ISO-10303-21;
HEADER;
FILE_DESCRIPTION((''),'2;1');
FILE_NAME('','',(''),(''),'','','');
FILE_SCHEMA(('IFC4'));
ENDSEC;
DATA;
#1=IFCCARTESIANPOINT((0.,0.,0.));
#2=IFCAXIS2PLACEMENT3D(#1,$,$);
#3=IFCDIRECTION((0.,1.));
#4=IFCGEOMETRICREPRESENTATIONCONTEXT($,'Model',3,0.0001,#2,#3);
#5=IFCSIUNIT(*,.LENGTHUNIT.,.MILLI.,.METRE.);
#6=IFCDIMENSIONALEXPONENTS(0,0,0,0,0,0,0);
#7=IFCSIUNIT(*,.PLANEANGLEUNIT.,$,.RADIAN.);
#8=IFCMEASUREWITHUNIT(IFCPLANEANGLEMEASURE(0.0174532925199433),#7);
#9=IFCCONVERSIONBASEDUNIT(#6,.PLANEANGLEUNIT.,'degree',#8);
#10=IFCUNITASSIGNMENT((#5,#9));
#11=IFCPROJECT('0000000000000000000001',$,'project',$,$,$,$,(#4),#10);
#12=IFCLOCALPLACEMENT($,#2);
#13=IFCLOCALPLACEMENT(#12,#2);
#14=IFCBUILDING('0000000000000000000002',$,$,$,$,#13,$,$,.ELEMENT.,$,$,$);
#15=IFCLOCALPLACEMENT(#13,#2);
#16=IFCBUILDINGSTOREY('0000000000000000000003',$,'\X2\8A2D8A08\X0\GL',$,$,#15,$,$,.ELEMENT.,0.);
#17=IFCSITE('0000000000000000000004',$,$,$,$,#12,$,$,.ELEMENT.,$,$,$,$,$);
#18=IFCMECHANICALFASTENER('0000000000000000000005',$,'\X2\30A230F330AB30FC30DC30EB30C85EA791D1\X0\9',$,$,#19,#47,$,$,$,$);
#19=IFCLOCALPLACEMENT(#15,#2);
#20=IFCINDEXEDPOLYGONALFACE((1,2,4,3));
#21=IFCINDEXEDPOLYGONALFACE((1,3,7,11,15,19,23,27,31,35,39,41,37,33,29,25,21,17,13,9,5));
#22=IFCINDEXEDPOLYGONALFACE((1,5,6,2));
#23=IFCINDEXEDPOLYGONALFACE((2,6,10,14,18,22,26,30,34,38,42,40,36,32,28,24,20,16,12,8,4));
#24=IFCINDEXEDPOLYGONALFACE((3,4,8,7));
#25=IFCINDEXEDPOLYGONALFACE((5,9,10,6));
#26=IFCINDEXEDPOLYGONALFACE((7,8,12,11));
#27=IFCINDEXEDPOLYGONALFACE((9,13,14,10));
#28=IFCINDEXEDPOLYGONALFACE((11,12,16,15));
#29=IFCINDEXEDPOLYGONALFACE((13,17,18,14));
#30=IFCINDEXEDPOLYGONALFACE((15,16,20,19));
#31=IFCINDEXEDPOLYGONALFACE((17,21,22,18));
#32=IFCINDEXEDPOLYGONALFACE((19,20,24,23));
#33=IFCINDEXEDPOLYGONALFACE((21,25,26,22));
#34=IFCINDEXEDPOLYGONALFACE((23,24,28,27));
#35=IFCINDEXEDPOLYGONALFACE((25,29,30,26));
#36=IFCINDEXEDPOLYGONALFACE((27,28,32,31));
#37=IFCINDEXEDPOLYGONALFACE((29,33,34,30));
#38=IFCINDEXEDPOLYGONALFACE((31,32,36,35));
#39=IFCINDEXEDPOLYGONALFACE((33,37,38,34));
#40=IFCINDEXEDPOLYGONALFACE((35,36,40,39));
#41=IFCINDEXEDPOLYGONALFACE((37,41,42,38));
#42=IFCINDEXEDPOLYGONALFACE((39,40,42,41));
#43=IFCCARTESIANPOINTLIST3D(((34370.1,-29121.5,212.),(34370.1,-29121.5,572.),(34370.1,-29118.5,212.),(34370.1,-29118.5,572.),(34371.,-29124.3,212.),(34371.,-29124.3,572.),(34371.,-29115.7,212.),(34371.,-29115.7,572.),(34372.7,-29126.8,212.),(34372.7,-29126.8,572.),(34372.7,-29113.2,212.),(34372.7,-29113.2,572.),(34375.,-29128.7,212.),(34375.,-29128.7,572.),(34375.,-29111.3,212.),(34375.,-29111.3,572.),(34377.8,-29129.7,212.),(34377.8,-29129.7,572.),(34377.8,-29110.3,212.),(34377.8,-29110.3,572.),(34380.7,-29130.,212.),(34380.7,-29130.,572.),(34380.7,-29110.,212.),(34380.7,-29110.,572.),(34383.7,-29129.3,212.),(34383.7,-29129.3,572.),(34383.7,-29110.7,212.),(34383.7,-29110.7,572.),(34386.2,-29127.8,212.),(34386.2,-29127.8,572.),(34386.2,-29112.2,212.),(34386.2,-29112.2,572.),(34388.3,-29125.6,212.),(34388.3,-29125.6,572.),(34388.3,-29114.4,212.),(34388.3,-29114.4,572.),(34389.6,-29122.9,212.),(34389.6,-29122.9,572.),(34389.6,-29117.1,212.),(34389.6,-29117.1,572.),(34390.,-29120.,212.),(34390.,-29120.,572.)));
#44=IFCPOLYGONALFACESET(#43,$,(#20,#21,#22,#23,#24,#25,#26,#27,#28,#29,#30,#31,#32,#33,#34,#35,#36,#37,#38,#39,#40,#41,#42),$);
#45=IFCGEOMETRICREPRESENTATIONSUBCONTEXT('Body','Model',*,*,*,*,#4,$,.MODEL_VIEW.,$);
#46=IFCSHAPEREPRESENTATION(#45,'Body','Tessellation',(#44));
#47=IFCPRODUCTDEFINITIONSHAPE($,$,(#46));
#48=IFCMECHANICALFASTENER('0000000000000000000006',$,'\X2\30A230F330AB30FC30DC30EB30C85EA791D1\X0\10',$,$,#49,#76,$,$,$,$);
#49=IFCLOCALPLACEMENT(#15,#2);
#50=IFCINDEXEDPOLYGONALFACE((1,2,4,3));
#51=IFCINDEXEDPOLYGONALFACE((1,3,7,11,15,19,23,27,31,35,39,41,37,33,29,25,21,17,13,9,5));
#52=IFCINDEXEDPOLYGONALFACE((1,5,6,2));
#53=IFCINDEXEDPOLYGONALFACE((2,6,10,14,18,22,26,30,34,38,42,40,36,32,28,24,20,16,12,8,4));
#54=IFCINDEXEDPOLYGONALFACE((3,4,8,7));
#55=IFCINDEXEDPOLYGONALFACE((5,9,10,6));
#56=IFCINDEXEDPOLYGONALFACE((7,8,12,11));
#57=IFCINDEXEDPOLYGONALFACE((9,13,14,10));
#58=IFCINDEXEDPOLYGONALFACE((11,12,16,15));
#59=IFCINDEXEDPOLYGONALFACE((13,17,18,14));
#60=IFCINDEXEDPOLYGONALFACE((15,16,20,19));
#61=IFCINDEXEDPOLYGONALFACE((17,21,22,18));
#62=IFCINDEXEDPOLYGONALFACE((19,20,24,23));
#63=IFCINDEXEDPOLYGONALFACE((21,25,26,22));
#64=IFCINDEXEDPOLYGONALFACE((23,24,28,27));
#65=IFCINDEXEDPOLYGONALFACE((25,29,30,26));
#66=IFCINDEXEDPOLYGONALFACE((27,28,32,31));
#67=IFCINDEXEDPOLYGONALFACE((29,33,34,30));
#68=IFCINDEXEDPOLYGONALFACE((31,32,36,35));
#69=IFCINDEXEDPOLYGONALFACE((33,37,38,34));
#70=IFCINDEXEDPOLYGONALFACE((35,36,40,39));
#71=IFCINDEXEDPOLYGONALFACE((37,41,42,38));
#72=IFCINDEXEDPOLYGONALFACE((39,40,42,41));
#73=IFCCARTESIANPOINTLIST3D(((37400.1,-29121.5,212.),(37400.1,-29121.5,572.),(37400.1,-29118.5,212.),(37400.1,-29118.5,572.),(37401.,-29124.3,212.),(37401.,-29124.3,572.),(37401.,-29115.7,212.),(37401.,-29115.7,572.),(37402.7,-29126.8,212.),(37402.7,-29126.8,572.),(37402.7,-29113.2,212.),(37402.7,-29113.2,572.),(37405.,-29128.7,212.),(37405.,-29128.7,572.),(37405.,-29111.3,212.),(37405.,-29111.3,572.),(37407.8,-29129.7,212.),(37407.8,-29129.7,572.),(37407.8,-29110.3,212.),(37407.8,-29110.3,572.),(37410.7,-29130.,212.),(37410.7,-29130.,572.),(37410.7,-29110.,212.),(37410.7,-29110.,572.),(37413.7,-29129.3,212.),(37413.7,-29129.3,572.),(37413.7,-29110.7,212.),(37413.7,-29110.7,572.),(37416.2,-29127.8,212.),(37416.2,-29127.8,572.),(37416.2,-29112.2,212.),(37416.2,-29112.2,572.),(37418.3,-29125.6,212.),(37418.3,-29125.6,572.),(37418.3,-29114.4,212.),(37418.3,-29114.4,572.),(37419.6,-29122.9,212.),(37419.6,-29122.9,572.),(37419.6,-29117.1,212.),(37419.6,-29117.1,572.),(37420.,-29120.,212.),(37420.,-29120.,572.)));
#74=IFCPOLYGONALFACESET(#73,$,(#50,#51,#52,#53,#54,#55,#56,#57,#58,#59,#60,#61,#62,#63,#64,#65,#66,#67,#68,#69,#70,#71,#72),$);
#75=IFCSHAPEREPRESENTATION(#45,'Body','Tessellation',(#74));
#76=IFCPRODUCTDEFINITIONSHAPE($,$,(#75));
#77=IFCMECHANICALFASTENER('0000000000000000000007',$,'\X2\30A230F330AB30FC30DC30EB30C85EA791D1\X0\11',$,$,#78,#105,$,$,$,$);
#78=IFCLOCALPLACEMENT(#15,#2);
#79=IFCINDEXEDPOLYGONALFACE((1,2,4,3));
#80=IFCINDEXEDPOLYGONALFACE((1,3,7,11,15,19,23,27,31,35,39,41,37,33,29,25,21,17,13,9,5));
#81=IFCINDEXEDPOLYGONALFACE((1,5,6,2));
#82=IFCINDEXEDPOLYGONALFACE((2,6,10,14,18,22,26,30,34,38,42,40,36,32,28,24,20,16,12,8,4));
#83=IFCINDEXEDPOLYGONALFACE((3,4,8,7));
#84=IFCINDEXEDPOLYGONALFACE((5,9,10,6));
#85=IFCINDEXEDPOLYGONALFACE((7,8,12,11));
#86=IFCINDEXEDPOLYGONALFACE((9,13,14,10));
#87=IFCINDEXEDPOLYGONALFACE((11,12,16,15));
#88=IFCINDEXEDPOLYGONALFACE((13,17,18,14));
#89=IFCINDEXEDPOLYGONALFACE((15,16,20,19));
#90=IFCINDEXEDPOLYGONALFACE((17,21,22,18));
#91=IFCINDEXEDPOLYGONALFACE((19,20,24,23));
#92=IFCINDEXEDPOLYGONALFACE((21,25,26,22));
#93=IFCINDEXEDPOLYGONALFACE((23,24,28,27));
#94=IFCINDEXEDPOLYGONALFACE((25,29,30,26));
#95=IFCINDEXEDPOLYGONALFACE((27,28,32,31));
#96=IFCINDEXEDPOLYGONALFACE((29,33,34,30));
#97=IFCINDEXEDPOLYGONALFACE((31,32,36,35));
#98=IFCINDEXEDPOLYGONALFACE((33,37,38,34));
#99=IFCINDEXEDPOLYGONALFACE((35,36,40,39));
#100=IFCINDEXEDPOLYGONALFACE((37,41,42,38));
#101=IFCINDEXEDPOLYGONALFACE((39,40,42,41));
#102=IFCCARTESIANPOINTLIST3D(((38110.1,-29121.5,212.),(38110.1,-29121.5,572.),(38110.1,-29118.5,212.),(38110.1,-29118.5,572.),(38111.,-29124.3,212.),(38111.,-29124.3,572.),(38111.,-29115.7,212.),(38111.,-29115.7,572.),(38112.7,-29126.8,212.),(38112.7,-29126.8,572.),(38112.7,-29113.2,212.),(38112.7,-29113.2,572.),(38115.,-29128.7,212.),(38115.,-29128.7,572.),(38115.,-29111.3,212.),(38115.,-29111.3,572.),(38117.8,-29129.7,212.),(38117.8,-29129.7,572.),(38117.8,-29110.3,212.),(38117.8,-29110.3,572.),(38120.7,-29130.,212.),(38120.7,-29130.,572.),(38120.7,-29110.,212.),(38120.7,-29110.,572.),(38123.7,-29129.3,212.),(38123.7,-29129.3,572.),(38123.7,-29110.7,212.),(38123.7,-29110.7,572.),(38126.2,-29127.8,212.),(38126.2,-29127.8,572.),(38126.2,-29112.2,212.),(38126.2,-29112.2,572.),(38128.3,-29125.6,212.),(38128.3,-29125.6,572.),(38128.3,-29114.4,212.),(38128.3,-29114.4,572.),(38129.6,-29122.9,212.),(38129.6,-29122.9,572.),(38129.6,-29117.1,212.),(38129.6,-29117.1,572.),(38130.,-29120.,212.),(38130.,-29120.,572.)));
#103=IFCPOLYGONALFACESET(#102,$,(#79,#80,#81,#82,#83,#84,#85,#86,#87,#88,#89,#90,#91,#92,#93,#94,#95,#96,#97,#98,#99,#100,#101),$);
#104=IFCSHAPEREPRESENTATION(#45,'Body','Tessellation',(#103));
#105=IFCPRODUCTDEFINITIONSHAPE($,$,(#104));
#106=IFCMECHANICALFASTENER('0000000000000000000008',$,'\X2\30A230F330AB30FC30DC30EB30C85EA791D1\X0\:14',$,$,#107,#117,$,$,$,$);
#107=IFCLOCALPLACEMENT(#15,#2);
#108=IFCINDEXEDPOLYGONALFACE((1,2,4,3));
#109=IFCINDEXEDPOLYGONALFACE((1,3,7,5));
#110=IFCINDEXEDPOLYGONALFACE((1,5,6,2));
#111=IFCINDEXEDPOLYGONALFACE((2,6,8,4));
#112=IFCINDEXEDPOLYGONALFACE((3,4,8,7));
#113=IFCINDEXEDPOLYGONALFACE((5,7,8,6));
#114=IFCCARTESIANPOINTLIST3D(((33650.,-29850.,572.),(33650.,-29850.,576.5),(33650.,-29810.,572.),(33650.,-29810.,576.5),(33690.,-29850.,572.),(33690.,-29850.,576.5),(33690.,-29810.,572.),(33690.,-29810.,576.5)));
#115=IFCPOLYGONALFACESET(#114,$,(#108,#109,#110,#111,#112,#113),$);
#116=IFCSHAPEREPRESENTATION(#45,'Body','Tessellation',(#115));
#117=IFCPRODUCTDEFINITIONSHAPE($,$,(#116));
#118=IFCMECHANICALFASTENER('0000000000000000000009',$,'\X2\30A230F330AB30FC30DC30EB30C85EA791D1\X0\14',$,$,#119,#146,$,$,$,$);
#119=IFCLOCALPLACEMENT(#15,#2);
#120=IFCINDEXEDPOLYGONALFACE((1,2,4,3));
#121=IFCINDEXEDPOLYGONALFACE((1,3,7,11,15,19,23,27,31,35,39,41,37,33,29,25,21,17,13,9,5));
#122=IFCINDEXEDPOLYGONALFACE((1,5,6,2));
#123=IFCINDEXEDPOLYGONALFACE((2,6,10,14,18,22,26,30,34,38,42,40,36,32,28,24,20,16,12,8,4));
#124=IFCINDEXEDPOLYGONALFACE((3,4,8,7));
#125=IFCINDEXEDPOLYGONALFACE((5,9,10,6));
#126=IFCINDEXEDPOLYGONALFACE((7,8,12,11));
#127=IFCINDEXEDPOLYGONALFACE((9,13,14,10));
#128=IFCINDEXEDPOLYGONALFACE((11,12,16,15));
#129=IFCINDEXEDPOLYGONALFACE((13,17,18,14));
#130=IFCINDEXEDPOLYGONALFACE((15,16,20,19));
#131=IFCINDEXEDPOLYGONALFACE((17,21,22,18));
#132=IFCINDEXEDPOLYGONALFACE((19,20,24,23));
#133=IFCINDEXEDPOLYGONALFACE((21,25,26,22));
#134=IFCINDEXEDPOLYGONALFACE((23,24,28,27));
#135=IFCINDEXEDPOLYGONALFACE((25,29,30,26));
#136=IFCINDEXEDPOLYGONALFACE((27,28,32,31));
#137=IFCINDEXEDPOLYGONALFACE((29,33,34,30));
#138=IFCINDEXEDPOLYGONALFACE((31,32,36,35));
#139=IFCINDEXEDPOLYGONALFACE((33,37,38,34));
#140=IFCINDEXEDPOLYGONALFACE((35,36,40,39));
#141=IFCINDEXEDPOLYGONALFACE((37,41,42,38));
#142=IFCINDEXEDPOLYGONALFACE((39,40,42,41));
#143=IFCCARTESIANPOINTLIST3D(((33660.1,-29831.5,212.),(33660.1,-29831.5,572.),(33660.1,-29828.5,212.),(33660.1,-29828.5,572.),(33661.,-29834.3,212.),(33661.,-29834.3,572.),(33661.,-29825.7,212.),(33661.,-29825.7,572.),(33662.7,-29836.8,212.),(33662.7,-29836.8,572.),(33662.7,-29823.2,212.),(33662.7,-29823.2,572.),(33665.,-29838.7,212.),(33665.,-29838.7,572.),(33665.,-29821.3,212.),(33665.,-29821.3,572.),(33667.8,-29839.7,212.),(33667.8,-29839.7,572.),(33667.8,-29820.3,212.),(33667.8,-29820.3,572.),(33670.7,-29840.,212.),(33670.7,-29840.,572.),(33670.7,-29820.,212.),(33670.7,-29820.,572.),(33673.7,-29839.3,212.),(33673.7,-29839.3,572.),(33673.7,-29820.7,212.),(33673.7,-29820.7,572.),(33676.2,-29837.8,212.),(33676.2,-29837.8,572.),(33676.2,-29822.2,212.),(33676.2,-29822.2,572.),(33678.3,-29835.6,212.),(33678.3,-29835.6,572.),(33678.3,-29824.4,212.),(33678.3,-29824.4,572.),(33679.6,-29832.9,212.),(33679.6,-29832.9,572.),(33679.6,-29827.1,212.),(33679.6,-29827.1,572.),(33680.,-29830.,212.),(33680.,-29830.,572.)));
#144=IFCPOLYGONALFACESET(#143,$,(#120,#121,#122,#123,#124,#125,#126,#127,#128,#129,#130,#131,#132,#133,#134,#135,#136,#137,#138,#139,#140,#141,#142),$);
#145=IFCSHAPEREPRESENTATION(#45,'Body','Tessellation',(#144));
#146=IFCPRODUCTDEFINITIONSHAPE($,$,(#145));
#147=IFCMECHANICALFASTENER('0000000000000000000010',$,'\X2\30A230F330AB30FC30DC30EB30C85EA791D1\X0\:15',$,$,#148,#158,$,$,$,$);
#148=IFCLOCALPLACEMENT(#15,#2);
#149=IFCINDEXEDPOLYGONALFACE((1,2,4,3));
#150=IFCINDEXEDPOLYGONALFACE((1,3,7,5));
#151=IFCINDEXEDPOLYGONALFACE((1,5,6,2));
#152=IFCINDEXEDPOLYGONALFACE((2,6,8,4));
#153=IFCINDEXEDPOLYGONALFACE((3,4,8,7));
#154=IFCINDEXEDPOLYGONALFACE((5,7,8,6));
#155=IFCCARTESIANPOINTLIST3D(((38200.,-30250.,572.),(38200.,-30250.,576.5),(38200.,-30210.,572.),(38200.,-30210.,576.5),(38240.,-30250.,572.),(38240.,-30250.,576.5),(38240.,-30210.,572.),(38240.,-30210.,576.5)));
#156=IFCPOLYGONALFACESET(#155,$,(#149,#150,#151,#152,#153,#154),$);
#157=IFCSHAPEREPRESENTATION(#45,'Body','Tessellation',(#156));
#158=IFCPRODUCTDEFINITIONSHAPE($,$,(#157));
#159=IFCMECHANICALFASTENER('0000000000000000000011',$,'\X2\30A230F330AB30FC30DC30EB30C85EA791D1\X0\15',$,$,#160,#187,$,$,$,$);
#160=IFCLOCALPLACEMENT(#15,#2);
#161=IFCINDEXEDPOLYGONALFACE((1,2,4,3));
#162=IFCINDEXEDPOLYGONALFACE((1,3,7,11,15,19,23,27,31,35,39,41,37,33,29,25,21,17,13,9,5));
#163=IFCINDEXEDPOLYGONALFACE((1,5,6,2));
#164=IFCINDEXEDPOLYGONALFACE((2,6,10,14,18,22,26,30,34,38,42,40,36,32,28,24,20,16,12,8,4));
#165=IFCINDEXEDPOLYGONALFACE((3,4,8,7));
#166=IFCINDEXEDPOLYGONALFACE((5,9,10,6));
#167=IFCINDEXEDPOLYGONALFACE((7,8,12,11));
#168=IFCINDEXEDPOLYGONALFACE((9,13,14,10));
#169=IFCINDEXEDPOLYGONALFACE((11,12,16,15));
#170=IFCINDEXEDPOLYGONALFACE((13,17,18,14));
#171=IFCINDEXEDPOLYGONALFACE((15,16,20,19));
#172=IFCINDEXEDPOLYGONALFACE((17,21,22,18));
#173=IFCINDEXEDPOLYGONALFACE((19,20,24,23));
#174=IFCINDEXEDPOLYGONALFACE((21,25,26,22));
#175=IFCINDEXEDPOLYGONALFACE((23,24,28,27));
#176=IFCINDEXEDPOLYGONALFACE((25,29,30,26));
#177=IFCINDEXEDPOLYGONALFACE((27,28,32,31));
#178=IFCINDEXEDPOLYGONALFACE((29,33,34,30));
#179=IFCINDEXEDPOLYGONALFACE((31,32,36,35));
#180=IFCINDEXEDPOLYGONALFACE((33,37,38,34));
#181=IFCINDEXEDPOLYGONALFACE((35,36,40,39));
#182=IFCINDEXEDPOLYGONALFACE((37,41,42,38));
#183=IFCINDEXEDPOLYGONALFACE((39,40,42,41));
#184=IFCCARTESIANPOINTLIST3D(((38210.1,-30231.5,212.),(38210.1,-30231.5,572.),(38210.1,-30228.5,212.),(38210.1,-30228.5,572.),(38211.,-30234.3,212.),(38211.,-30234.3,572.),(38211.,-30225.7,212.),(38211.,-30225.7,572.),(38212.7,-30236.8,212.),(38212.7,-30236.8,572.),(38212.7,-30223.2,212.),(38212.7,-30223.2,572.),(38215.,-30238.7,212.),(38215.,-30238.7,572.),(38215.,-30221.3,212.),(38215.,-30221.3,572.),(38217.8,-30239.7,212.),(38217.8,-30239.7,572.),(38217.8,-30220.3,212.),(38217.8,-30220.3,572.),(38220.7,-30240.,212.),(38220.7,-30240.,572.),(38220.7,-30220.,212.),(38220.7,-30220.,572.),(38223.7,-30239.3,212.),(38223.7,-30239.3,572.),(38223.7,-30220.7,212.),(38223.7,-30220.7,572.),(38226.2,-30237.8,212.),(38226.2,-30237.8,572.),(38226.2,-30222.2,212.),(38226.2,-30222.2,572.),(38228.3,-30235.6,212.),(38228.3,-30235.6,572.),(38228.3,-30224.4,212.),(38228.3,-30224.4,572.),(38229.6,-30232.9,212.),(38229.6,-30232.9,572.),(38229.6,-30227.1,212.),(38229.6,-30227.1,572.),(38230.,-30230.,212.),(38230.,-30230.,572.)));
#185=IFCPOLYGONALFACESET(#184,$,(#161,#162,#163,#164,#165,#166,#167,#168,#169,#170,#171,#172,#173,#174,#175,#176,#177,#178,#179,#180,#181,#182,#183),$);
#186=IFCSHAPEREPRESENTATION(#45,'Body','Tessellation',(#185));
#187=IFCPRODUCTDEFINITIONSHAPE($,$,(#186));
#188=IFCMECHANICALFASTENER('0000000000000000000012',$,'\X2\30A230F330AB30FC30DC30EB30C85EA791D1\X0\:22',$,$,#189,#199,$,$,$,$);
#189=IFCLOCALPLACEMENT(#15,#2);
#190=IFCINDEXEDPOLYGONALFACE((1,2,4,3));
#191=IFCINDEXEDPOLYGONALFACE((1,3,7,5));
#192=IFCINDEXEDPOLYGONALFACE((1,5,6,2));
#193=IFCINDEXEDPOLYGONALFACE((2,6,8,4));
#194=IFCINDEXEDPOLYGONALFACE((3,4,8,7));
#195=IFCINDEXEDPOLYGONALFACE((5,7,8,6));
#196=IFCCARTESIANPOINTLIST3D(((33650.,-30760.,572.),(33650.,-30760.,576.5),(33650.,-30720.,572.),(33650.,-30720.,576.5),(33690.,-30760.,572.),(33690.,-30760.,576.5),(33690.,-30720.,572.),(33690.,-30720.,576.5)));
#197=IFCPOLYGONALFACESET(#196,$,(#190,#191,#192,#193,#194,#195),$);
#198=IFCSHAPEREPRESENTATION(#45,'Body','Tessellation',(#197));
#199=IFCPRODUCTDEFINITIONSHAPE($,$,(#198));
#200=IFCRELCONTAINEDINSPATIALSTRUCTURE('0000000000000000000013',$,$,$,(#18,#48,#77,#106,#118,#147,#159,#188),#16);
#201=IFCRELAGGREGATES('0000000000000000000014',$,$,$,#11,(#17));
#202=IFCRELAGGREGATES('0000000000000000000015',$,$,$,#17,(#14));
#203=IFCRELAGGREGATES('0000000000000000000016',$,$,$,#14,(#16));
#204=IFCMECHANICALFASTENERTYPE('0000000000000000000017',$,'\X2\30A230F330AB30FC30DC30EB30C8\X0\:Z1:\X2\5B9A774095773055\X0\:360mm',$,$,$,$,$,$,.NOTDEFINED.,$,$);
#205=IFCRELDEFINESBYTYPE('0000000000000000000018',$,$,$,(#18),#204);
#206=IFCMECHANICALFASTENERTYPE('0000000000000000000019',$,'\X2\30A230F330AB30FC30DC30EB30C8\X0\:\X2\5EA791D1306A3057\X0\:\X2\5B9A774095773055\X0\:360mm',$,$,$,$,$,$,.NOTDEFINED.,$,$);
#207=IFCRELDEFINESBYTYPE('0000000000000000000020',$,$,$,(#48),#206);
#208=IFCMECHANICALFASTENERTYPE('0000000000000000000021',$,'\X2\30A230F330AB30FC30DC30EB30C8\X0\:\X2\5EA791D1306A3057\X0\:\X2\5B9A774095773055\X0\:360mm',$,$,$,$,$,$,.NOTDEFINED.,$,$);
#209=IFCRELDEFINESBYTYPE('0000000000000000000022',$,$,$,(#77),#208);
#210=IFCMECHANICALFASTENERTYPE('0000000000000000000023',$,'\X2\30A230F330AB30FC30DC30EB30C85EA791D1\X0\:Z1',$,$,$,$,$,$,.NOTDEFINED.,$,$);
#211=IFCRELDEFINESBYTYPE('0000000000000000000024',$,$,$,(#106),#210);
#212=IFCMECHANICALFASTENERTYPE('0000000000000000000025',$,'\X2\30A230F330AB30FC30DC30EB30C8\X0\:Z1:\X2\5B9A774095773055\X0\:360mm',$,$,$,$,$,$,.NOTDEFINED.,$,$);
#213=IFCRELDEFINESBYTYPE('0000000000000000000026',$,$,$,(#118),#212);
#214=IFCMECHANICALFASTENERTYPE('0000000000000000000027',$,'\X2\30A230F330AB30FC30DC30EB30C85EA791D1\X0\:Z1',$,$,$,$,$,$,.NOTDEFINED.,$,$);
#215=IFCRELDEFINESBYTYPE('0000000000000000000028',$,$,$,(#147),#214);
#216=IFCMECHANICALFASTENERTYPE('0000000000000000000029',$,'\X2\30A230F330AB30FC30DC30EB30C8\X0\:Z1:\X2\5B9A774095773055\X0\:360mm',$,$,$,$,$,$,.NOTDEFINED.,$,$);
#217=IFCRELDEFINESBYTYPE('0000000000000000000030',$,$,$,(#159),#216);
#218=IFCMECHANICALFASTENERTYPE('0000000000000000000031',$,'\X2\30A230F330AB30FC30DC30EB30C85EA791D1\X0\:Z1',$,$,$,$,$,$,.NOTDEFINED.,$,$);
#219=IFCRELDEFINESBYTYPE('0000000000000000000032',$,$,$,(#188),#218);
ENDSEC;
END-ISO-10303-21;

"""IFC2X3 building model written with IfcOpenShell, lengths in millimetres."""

from ifc_helpers import new_model, entity, si_unit, converted_unit, direction, frame, origin, origin_with_axes, origin_2d, place, context, subcontext, project, spatial, rectangle, circle, extrude, type_object, element, save


model = new_model("IFC2X3")

# Units and contexts
model_context = context("Model", 3, precision=0.0001, world=origin(), true_north=direction((0.0, 1.0)))
body_context = subcontext(model_context, "Body", "Model", "MODEL_VIEW")
ifc_project = project(units=[si_unit("LENGTHUNIT", "METRE", prefix="MILLI"), converted_unit("PLANEANGLEUNIT", "degree", entity("IfcPlaneAngleMeasure", 0.0174532925199433), si_unit("PLANEANGLEUNIT", "RADIAN"), dimensions=[0, 0, 0, 0, 0, 0, 0])], contexts=[model_context])

# Site, building, storey
site_placement = place(None, origin())
site = spatial("IfcSite", under=ifc_project, at=site_placement, CompositionType="ELEMENT")
building_placement = place(site_placement, origin())
building = spatial("IfcBuilding", under=site, at=building_placement, CompositionType="ELEMENT")
storey_placement = place(building_placement, origin())
storey = spatial("IfcBuildingStorey", under=building, at=storey_placement, Name="設計GL", CompositionType="ELEMENT", Elevation=0.0)

# Mechanical fasteners
mechanical_fastener_type_1 = type_object("IfcMechanicalFastenerType", Name="アンカーボルト:Z1:定着長さ:360mm")
mechanical_fastener_1_placement = place(storey_placement, frame((34380.0, -29120.0, 212.0)))
element("IfcMechanicalFastener", 1, at=mechanical_fastener_1_placement, inside=storey, type_object=mechanical_fastener_type_1, Name="アンカーボルト座金9", context=body_context, shape_type="SweptSolid", body=[
    extrude(circle(Radius=10.0, at=origin_2d()), origin_with_axes(), (0.0, 0.0, 1.0), 360.0),
])
mechanical_fastener_type_2 = type_object("IfcMechanicalFastenerType", Name="アンカーボルト:座金なし:定着長さ:360mm")
mechanical_fastener_2_placement = place(storey_placement, frame((37410.0, -29120.0, 212.0)))
element("IfcMechanicalFastener", 2, at=mechanical_fastener_2_placement, inside=storey, type_object=mechanical_fastener_type_2, Name="アンカーボルト座金10", context=body_context, shape_type="SweptSolid", body=[
    extrude(circle(Radius=10.0, at=origin_2d()), origin_with_axes(), (0.0, 0.0, 1.0), 360.0),
])
mechanical_fastener_type_3 = type_object("IfcMechanicalFastenerType", Name="アンカーボルト:座金なし:定着長さ:360mm")
mechanical_fastener_3_placement = place(storey_placement, frame((38120.0, -29120.0, 212.0)))
element("IfcMechanicalFastener", 3, at=mechanical_fastener_3_placement, inside=storey, type_object=mechanical_fastener_type_3, Name="アンカーボルト座金11", context=body_context, shape_type="SweptSolid", body=[
    extrude(circle(Radius=10.0, at=origin_2d()), origin_with_axes(), (0.0, 0.0, 1.0), 360.0),
])
mechanical_fastener_type_4 = type_object("IfcMechanicalFastenerType", Name="アンカーボルト座金:Z1")
mechanical_fastener_4_placement = place(storey_placement, frame((33670.0, -29830.0, 572.0)))
element("IfcMechanicalFastener", 4, at=mechanical_fastener_4_placement, inside=storey, type_object=mechanical_fastener_type_4, Name="アンカーボルト座金:14", context=body_context, shape_type="SweptSolid", body=[
    extrude(rectangle(XDim=40.0, YDim=40.0, at=origin_2d()), origin_with_axes(), (0.0, 0.0, 1.0), 4.5),
])
mechanical_fastener_type_5 = type_object("IfcMechanicalFastenerType", Name="アンカーボルト:Z1:定着長さ:360mm")
mechanical_fastener_5_placement = place(storey_placement, frame((33670.0, -29830.0, 212.0)))
element("IfcMechanicalFastener", 5, at=mechanical_fastener_5_placement, inside=storey, type_object=mechanical_fastener_type_5, Name="アンカーボルト座金14", context=body_context, shape_type="SweptSolid", body=[
    extrude(circle(Radius=10.0, at=origin_2d()), origin_with_axes(), (0.0, 0.0, 1.0), 360.0),
])
mechanical_fastener_type_6 = type_object("IfcMechanicalFastenerType", Name="アンカーボルト座金:Z1")
mechanical_fastener_6_placement = place(storey_placement, frame((38220.0, -30230.0, 572.0)))
element("IfcMechanicalFastener", 6, at=mechanical_fastener_6_placement, inside=storey, type_object=mechanical_fastener_type_6, Name="アンカーボルト座金:15", context=body_context, shape_type="SweptSolid", body=[
    extrude(rectangle(XDim=40.0, YDim=40.0, at=origin_2d()), origin_with_axes(), (0.0, 0.0, 1.0), 4.5),
])
mechanical_fastener_type_7 = type_object("IfcMechanicalFastenerType", Name="アンカーボルト:Z1:定着長さ:360mm")
mechanical_fastener_7_placement = place(storey_placement, frame((38220.0, -30230.0, 212.0)))
element("IfcMechanicalFastener", 7, at=mechanical_fastener_7_placement, inside=storey, type_object=mechanical_fastener_type_7, Name="アンカーボルト座金15", context=body_context, shape_type="SweptSolid", body=[
    extrude(circle(Radius=10.0, at=origin_2d()), origin_with_axes(), (0.0, 0.0, 1.0), 360.0),
])
mechanical_fastener_type_8 = type_object("IfcMechanicalFastenerType", Name="アンカーボルト座金:Z1")
mechanical_fastener_8_placement = place(storey_placement, frame((33670.0, -30740.0, 572.0)))
element("IfcMechanicalFastener", 8, at=mechanical_fastener_8_placement, inside=storey, type_object=mechanical_fastener_type_8, Name="アンカーボルト座金:22", context=body_context, shape_type="SweptSolid", body=[
    extrude(rectangle(XDim=40.0, YDim=40.0, at=origin_2d()), origin_with_axes(), (0.0, 0.0, 1.0), 4.5),
])

save(model, "model.ifc")
